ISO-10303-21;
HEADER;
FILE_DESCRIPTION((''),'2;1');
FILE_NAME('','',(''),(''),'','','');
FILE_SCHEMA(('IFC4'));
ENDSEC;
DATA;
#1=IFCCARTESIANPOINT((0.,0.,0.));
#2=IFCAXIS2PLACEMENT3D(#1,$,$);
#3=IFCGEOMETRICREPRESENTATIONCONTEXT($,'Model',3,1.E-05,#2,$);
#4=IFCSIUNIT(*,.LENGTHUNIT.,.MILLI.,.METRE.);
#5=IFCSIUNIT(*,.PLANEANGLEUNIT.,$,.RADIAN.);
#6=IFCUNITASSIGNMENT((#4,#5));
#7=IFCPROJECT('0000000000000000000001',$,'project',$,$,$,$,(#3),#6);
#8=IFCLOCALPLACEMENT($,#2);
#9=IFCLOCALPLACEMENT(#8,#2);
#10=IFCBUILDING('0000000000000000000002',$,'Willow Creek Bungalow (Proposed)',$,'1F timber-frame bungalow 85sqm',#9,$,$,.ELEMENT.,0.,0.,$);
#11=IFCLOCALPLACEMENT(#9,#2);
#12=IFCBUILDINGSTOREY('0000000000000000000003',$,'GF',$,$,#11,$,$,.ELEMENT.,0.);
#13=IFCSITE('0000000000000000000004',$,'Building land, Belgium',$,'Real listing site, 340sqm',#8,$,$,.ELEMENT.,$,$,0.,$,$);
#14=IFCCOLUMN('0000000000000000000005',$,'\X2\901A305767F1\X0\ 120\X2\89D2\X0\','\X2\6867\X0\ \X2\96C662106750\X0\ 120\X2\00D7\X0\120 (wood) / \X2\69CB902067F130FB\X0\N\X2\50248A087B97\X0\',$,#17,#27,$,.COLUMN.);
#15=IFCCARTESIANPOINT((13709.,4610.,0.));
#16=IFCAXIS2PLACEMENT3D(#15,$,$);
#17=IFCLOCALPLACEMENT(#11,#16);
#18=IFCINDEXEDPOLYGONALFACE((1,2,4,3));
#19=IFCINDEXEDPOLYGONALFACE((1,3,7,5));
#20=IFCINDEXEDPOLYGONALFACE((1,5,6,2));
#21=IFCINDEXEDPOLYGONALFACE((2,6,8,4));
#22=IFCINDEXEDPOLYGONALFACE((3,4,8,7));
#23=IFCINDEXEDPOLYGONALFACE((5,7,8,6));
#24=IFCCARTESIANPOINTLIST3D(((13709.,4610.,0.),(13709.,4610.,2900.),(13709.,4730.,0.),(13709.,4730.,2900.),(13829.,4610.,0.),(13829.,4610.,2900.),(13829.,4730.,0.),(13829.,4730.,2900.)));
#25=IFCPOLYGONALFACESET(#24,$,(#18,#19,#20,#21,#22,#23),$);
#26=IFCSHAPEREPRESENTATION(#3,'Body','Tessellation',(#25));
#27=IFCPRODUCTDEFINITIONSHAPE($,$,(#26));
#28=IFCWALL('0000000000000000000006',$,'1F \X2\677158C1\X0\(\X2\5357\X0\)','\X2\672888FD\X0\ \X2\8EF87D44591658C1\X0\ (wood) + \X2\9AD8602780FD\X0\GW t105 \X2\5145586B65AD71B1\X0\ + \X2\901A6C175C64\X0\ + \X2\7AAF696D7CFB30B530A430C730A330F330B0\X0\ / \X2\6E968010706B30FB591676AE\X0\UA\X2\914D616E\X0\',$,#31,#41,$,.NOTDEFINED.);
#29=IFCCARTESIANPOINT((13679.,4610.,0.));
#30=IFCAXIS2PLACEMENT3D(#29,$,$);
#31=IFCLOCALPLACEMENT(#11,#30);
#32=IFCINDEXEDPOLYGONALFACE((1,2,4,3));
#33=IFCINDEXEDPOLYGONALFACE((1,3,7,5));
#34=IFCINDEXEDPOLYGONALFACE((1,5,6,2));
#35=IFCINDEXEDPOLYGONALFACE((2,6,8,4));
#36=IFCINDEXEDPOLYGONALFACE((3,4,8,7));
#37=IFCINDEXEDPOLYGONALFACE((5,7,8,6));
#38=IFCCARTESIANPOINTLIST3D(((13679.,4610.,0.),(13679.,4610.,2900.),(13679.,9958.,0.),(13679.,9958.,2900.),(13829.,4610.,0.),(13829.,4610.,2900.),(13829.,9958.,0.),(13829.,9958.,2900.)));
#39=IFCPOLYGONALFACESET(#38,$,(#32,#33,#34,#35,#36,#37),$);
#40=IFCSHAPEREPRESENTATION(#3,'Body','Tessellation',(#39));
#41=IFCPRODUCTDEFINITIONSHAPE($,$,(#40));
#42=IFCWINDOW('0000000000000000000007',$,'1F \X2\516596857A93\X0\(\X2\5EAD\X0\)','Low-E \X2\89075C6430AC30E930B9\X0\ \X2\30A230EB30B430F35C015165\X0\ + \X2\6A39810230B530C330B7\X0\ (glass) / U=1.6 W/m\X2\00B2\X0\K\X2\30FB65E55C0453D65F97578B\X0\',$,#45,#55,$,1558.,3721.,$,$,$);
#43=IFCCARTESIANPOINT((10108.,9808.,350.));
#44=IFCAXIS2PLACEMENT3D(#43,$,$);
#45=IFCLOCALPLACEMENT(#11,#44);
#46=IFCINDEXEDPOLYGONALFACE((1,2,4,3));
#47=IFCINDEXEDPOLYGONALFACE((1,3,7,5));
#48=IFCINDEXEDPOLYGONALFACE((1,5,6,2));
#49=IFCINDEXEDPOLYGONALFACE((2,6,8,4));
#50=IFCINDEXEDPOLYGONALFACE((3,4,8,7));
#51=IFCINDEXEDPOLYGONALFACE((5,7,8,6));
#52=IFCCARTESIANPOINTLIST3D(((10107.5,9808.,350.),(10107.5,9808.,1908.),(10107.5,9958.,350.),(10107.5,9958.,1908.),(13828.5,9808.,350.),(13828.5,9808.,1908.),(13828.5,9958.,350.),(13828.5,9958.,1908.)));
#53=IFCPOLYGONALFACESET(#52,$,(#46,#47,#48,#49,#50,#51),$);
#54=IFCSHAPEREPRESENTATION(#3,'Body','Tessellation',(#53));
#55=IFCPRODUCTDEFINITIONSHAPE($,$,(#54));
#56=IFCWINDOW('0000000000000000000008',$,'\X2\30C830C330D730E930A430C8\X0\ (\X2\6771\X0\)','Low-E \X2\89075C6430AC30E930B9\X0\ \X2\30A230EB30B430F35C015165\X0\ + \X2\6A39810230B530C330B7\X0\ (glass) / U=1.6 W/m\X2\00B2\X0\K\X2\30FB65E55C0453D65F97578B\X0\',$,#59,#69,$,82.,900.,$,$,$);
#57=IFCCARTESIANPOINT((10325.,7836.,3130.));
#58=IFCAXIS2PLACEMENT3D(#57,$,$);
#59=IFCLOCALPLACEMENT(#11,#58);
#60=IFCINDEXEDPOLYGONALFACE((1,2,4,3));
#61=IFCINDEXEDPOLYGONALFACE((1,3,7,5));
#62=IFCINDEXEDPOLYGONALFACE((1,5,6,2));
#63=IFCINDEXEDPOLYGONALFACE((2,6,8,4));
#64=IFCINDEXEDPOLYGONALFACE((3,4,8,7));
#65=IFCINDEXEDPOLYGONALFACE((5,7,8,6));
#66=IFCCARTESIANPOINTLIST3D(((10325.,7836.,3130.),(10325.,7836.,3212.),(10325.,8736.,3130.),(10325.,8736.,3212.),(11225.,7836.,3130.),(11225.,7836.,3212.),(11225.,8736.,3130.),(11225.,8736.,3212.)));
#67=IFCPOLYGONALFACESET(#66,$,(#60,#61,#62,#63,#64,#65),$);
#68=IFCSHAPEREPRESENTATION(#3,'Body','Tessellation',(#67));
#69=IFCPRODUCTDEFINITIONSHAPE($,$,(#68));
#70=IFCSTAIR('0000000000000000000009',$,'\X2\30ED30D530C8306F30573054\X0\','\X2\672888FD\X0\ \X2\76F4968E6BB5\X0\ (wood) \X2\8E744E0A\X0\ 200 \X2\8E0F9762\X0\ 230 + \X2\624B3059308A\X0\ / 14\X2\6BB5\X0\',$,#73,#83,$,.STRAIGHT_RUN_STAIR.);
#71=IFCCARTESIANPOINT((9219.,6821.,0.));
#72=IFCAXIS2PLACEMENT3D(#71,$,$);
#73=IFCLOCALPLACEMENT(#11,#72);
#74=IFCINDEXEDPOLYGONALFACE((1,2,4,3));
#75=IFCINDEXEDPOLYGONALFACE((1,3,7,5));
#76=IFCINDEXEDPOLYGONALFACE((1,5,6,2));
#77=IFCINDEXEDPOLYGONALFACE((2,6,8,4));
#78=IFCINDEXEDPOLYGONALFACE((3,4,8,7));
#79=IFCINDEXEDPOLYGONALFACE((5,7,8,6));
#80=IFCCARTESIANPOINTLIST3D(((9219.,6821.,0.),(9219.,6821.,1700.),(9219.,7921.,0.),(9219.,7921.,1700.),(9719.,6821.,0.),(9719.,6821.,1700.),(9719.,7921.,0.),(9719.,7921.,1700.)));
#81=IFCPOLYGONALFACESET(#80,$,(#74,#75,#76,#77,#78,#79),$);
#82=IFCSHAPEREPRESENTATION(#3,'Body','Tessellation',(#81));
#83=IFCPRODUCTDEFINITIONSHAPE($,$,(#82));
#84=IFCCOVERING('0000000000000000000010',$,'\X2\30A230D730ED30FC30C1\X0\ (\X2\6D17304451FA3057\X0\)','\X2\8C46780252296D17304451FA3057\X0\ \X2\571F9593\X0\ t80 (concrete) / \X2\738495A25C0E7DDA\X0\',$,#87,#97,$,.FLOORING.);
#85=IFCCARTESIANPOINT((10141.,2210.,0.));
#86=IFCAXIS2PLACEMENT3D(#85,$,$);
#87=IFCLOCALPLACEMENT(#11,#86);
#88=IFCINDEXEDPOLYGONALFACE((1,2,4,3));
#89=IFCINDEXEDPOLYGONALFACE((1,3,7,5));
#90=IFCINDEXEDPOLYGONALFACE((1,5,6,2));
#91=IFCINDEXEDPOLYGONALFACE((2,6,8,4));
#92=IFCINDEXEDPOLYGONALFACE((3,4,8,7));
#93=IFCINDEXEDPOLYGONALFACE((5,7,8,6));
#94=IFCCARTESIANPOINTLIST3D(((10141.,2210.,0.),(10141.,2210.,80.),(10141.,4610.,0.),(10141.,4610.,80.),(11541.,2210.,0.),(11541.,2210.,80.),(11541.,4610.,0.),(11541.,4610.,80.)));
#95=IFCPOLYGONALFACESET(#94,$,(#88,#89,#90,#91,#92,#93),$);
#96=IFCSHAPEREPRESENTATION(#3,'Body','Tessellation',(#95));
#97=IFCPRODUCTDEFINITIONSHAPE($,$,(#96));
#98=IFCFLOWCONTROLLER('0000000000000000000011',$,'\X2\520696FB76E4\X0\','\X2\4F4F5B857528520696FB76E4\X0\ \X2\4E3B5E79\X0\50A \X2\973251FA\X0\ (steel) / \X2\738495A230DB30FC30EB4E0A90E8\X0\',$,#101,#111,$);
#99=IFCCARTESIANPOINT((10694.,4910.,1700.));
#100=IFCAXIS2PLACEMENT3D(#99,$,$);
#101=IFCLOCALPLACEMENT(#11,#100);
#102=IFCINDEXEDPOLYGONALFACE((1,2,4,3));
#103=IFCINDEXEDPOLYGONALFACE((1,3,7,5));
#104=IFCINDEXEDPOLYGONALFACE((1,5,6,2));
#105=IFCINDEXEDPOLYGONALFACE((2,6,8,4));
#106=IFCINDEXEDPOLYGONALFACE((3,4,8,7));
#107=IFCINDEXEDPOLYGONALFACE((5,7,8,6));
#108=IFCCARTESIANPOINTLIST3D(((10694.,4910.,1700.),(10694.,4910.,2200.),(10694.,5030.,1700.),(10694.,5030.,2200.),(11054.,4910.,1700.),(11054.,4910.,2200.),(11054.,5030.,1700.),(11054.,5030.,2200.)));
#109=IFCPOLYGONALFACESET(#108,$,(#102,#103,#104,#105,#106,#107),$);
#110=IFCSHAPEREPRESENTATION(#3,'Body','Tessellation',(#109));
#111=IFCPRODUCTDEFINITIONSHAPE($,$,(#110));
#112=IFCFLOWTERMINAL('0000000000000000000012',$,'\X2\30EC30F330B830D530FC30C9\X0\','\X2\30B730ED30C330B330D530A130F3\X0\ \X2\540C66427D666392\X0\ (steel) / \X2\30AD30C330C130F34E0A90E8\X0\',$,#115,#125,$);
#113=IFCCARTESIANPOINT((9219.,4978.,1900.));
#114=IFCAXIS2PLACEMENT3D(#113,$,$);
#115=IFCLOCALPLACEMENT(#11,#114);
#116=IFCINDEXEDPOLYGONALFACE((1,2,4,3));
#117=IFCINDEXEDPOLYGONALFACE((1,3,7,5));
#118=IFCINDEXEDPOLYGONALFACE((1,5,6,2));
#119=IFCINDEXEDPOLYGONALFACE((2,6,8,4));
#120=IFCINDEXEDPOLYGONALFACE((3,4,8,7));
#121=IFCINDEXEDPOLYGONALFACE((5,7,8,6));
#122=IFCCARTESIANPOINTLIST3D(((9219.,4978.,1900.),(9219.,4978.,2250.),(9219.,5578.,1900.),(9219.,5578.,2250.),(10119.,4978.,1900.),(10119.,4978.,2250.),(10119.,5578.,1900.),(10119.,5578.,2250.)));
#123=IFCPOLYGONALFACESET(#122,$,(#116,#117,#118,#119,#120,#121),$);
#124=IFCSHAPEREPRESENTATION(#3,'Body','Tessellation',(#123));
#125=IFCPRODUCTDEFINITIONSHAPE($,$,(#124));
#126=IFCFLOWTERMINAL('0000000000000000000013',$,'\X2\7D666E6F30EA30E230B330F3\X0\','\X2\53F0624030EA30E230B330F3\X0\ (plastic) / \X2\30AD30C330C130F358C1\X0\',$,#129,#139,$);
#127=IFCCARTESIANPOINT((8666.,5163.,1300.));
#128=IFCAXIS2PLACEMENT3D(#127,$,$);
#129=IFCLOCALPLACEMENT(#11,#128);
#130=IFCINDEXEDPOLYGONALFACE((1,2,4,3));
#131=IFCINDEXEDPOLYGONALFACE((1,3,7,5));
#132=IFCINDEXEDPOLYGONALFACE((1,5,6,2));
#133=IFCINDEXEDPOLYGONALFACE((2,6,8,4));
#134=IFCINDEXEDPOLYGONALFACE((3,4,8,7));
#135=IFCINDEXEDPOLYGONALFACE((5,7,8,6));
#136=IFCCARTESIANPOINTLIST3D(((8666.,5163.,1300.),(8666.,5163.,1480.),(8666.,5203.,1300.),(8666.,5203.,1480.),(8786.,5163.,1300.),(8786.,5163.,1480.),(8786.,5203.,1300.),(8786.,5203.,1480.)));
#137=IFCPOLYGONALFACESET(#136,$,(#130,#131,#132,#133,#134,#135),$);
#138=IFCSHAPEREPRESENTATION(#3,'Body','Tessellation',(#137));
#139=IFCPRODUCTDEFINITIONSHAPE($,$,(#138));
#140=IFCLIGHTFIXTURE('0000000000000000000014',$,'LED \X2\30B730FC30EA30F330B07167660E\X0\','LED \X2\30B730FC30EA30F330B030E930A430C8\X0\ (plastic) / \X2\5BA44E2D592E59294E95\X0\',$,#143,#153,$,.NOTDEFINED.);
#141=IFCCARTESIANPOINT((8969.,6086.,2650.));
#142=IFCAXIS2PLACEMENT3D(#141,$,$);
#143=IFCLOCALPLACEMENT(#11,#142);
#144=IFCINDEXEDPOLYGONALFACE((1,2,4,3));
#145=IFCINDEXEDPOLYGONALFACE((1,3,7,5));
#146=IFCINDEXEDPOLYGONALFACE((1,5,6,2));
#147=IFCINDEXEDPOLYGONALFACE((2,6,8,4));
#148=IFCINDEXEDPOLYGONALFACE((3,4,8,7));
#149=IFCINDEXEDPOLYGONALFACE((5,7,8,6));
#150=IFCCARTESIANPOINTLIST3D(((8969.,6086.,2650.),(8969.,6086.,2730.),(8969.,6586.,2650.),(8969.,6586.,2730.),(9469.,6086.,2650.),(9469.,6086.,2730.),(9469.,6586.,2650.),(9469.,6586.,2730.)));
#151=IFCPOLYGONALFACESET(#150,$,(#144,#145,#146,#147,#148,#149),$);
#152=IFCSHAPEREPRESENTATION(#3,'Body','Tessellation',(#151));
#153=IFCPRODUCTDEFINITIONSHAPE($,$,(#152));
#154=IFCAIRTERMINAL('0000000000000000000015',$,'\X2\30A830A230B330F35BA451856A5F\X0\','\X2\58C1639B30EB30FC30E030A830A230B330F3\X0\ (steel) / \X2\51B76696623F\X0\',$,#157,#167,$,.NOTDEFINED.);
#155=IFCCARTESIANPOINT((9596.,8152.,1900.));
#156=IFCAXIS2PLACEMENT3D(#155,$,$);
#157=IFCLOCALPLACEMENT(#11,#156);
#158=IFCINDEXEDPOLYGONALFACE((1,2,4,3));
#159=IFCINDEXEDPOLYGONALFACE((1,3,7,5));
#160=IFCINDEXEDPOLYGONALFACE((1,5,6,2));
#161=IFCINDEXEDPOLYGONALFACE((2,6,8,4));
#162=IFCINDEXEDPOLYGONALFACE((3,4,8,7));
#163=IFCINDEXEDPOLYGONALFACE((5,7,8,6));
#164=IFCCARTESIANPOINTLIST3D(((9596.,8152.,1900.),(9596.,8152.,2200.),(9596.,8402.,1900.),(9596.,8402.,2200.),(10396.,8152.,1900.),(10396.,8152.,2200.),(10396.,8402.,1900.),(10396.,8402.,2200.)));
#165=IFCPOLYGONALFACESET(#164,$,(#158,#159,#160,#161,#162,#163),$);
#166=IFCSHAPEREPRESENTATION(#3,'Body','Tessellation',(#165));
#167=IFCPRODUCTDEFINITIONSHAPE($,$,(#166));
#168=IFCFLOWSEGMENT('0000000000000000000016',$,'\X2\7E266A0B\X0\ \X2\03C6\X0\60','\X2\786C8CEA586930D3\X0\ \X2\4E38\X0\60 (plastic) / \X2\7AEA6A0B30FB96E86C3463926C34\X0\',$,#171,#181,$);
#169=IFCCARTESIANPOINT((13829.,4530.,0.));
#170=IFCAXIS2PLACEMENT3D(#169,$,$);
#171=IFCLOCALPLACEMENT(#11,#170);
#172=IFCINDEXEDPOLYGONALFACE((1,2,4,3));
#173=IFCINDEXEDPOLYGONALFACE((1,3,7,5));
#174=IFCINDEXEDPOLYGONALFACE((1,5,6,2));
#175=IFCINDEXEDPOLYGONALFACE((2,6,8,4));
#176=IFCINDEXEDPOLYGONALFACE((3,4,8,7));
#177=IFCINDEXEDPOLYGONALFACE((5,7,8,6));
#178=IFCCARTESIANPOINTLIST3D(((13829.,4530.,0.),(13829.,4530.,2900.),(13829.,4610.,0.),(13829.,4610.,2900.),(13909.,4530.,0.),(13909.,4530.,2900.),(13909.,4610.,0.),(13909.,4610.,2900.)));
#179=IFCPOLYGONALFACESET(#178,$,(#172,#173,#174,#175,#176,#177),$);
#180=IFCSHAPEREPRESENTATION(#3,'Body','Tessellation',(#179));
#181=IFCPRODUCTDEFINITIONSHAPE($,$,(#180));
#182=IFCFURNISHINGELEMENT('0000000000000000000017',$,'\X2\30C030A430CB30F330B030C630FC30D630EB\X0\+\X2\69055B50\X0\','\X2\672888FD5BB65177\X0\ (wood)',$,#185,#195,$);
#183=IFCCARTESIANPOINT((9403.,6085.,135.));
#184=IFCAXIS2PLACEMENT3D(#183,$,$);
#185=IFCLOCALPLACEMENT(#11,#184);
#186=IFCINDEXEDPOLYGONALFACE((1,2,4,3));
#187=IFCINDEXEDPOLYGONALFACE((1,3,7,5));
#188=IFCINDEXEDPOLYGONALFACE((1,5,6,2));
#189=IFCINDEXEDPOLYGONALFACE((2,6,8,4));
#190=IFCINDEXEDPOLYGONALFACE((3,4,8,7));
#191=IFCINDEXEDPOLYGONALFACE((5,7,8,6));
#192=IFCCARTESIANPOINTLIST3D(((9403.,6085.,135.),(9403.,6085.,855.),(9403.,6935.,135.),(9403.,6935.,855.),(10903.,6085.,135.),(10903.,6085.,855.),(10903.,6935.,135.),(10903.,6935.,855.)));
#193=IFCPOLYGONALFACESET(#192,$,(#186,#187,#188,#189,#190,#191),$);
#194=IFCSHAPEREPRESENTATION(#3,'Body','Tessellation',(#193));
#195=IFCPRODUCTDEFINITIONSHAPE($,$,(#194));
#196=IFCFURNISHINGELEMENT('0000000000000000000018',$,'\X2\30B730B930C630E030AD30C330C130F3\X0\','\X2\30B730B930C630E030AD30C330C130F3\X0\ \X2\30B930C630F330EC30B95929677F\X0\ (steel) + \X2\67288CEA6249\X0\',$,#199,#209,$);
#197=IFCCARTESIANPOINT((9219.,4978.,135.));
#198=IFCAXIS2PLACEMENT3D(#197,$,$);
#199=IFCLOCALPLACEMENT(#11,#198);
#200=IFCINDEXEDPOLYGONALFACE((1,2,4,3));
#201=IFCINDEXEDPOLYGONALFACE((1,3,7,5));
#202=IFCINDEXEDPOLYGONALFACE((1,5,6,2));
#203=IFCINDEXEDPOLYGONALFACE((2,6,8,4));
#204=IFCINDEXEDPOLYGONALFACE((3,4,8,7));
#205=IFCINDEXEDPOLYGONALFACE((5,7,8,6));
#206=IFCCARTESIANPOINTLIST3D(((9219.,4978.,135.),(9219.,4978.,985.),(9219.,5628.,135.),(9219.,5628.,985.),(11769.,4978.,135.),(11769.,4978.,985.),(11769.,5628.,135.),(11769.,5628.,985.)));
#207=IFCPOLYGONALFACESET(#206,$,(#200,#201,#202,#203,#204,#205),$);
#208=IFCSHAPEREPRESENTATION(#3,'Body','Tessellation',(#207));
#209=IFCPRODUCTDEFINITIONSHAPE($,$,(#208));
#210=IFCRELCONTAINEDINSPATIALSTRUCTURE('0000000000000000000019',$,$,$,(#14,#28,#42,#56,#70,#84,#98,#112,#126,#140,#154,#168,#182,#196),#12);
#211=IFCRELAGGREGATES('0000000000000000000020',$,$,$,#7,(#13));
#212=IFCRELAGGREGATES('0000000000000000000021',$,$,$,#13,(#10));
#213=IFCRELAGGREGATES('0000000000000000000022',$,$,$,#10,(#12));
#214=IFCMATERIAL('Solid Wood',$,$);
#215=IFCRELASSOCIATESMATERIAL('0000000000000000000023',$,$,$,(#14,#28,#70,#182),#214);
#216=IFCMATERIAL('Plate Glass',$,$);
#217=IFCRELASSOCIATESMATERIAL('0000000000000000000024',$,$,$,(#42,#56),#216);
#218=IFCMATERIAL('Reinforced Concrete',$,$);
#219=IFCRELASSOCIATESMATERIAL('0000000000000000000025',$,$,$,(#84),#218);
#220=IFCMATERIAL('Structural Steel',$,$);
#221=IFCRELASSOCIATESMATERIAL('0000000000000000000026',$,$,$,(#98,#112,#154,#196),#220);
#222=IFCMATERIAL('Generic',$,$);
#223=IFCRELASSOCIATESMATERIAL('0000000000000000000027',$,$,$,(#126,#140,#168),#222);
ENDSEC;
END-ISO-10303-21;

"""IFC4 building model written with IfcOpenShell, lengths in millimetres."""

from ifc_helpers import new_model, si_unit, frame, frame_2d, origin, place, context, project, spatial, rectangle, extrude, material, element, fill, save


model = new_model("IFC4")

# Units and contexts
model_context = context("Model", 3, precision=1e-05, world=origin())
ifc_project = project(units=[si_unit("LENGTHUNIT", "METRE", prefix="MILLI"), si_unit("PLANEANGLEUNIT", "RADIAN")], contexts=[model_context])

# Site, building, storey
site_placement = place(None, origin())
site = spatial("IfcSite", under=ifc_project, at=site_placement, Name="Building land, Belgium", ObjectType="Real listing site, 340sqm", CompositionType="ELEMENT", RefElevation=0.0)
building_placement = place(site_placement, origin())
building = spatial("IfcBuilding", under=site, at=building_placement, Name="Willow Creek Bungalow (Proposed)", ObjectType="1F timber-frame bungalow 85sqm", CompositionType="ELEMENT", ElevationOfRefHeight=0.0, ElevationOfTerrain=0.0)
storey_placement = place(building_placement, origin())
storey = spatial("IfcBuildingStorey", under=building, at=storey_placement, Name="GF", CompositionType="ELEMENT", Elevation=0.0)

# Column
ifc_material_1 = material(Name="Solid Wood")
column_1_placement = place(storey_placement, frame((13709.0, 4610.0, 0.0)))
element("IfcColumn", 1, at=column_1_placement, inside=storey, material=ifc_material_1, Name="通し柱 120角", Description="桧 集成材 120×120 (wood) / 構造柱・N値計算", PredefinedType="COLUMN", context=model_context, shape_type="SweptSolid", body=[
    extrude(rectangle(XDim=120.0, YDim=120.0, at=frame_2d((60.0, 60.0))), frame((13709.0, 4610.0, 0.0)), (0.0, 0.0, 1.0), 2900.0),
])

# Wall, opening, window
wall_1_placement = place(storey_placement, frame((13679.0, 4610.0, 0.0)))
wall_1 = element("IfcWall", 2, at=wall_1_placement, inside=storey, material=ifc_material_1, Name="1F 東壁(南)", Description="木製 軸組外壁 (wood) + 高性能GW t105 充填断熱 + 通気層 + 窯業系サイディング / 準耐火・外皮UA配慮", PredefinedType="NOTDEFINED", context=model_context, shape_type="SweptSolid", body=[
    extrude(rectangle(XDim=150.0, YDim=5348.0, at=frame_2d((75.0, 2674.0))), frame((13679.0, 4610.0, 0.0)), (0.0, 0.0, 1.0), 2900.0),
])
opening_placement = place(storey_placement, frame((10108.0, 9808.0, 350.0)))
opening = element("IfcOpeningElement", 3, at=opening_placement, cuts=wall_1, PredefinedType="NOTDEFINED", context=model_context, shape_type="SweptSolid", body=[
    extrude(rectangle(XDim=3721.0, YDim=150.0, at=frame_2d((1860.0, 75.0))), frame((10108.0, 9808.0, 350.0)), (0.0, 0.0, 1.0), 1558.0),
])
ifc_material_2 = material(Name="Plate Glass")
window_1_placement = place(storey_placement, frame((10108.0, 9808.0, 350.0)))
window_1 = element("IfcWindow", 4, at=window_1_placement, inside=storey, material=ifc_material_2, Name="1F 入隅窓(庭)", Description="Low-E 複層ガラス アルゴン封入 + 樹脂サッシ (glass) / U=1.6 W/m²K・日射取得型", OverallHeight=1558.0, OverallWidth=3721.0, context=model_context, shape_type="SweptSolid", body=[
    extrude(rectangle(XDim=3721.0, YDim=150.0, at=frame_2d((1860.0, 75.0))), frame((10108.0, 9808.0, 350.0)), (0.0, 0.0, 1.0), 1558.0),
])
fill(opening, window_1)

# Window
window_2_placement = place(storey_placement, frame((10325.0, 7836.0, 3130.0)))
element("IfcWindow", 5, at=window_2_placement, inside=storey, material=ifc_material_2, Name="トップライト (東)", Description="Low-E 複層ガラス アルゴン封入 + 樹脂サッシ (glass) / U=1.6 W/m²K・日射取得型", OverallHeight=82.0, OverallWidth=900.0, context=model_context, shape_type="SweptSolid", body=[
    extrude(rectangle(XDim=900.0, YDim=900.0, at=frame_2d((450.0, 450.0))), frame((10325.0, 7836.0, 3130.0)), (0.0, 0.0, 1.0), 82.0),
])

# Stair
stair_placement = place(storey_placement, frame((9219.0, 6821.0, 0.0)))
element("IfcStair", 6, at=stair_placement, inside=storey, material=ifc_material_1, Name="ロフトはしご", Description="木製 直階段 (wood) 蹴上 200 踏面 230 + 手すり / 14段", PredefinedType="STRAIGHT_RUN_STAIR", context=model_context, shape_type="SweptSolid", body=[
    extrude(rectangle(XDim=500.0, YDim=1100.0, at=frame_2d((250.0, 550.0))), frame((9219.0, 6821.0, 0.0)), (0.0, 0.0, 1.0), 1700.0),
])

# Covering
ifc_material_3 = material(Name="Reinforced Concrete")
covering_placement = place(storey_placement, frame((10141.0, 2210.0, 0.0)))
element("IfcCovering", 7, at=covering_placement, inside=storey, material=ifc_material_3, Name="アプローチ (洗い出し)", Description="豆砂利洗い出し 土間 t80 (concrete) / 玄関導線", PredefinedType="FLOORING", context=model_context, shape_type="SweptSolid", body=[
    extrude(rectangle(XDim=1400.0, YDim=2400.0, at=frame_2d((700.0, 1200.0))), frame((10141.0, 2210.0, 0.0)), (0.0, 0.0, 1.0), 80.0),
])

# Flow controller
ifc_material_4 = material(Name="Structural Steel")
flow_controller_placement = place(storey_placement, frame((10694.0, 4910.0, 1700.0)))
element("IfcFlowController", 8, at=flow_controller_placement, inside=storey, material=ifc_material_4, Name="分電盤", Description="住宅用分電盤 主幹50A 露出 (steel) / 玄関ホール上部", context=model_context, shape_type="SweptSolid", body=[
    extrude(rectangle(XDim=360.0, YDim=120.0, at=frame_2d((180.0, 60.0))), frame((10694.0, 4910.0, 1700.0)), (0.0, 0.0, 1.0), 500.0),
])

# Flow terminals
flow_terminal_1_placement = place(storey_placement, frame((9219.0, 4978.0, 1900.0)))
element("IfcFlowTerminal", 9, at=flow_terminal_1_placement, inside=storey, material=ifc_material_4, Name="レンジフード", Description="シロッコファン 同時給排 (steel) / キッチン上部", context=model_context, shape_type="SweptSolid", body=[
    extrude(rectangle(XDim=900.0, YDim=600.0, at=frame_2d((450.0, 300.0))), frame((9219.0, 4978.0, 1900.0)), (0.0, 0.0, 1.0), 350.0),
])
ifc_material_5 = material(Name="Generic")
flow_terminal_2_placement = place(storey_placement, frame((8666.0, 5163.0, 1300.0)))
element("IfcFlowTerminal", 10, at=flow_terminal_2_placement, inside=storey, material=ifc_material_5, Name="給湯リモコン", Description="台所リモコン (plastic) / キッチン壁", context=model_context, shape_type="SweptSolid", body=[
    extrude(rectangle(XDim=120.0, YDim=40.0, at=frame_2d((60.0, 20.0))), frame((8666.0, 5163.0, 1300.0)), (0.0, 0.0, 1.0), 180.0),
])

# Light fixture
light_fixture_placement = place(storey_placement, frame((8969.0, 6086.0, 2650.0)))
element("IfcLightFixture", 11, at=light_fixture_placement, inside=storey, material=ifc_material_5, Name="LED シーリング照明", Description="LED シーリングライト (plastic) / 室中央天井", PredefinedType="NOTDEFINED", context=model_context, shape_type="SweptSolid", body=[
    extrude(rectangle(XDim=500.0, YDim=500.0, at=frame_2d((250.0, 250.0))), frame((8969.0, 6086.0, 2650.0)), (0.0, 0.0, 1.0), 80.0),
])

# Air terminal
air_terminal_placement = place(storey_placement, frame((9596.0, 8152.0, 1900.0)))
element("IfcAirTerminal", 12, at=air_terminal_placement, inside=storey, material=ifc_material_4, Name="エアコン室内機", Description="壁掛ルームエアコン (steel) / 冷暖房", PredefinedType="NOTDEFINED", context=model_context, shape_type="SweptSolid", body=[
    extrude(rectangle(XDim=800.0, YDim=250.0, at=frame_2d((400.0, 125.0))), frame((9596.0, 8152.0, 1900.0)), (0.0, 0.0, 1.0), 300.0),
])

# Flow segment
flow_segment_placement = place(storey_placement, frame((13829.0, 4530.0, 0.0)))
element("IfcFlowSegment", 13, at=flow_segment_placement, inside=storey, material=ifc_material_5, Name="縦樋 φ60", Description="硬質塩ビ 丸60 (plastic) / 竪樋・雨水排水", context=model_context, shape_type="SweptSolid", body=[
    extrude(rectangle(XDim=80.0, YDim=80.0, at=frame_2d((40.0, 40.0))), frame((13829.0, 4530.0, 0.0)), (0.0, 0.0, 1.0), 2900.0),
])

# Furnishing elements
furnishing_1_placement = place(storey_placement, frame((9403.0, 6085.0, 135.0)))
element("IfcFurnishingElement", 14, at=furnishing_1_placement, inside=storey, material=ifc_material_1, Name="ダイニングテーブル+椅子", Description="木製家具 (wood)", context=model_context, shape_type="SweptSolid", body=[
    extrude(rectangle(XDim=1500.0, YDim=850.0, at=frame_2d((750.0, 425.0))), frame((9403.0, 6085.0, 135.0)), (0.0, 0.0, 1.0), 720.0),
])
furnishing_2_placement = place(storey_placement, frame((9219.0, 4978.0, 135.0)))
element("IfcFurnishingElement", 15, at=furnishing_2_placement, inside=storey, material=ifc_material_4, Name="システムキッチン", Description="システムキッチン ステンレス天板 (steel) + 木質扉", context=model_context, shape_type="SweptSolid", body=[
    extrude(rectangle(XDim=2550.0, YDim=650.0, at=frame_2d((1275.0, 325.0))), frame((9219.0, 4978.0, 135.0)), (0.0, 0.0, 1.0), 850.0),
])

save(model, "model.ifc")
